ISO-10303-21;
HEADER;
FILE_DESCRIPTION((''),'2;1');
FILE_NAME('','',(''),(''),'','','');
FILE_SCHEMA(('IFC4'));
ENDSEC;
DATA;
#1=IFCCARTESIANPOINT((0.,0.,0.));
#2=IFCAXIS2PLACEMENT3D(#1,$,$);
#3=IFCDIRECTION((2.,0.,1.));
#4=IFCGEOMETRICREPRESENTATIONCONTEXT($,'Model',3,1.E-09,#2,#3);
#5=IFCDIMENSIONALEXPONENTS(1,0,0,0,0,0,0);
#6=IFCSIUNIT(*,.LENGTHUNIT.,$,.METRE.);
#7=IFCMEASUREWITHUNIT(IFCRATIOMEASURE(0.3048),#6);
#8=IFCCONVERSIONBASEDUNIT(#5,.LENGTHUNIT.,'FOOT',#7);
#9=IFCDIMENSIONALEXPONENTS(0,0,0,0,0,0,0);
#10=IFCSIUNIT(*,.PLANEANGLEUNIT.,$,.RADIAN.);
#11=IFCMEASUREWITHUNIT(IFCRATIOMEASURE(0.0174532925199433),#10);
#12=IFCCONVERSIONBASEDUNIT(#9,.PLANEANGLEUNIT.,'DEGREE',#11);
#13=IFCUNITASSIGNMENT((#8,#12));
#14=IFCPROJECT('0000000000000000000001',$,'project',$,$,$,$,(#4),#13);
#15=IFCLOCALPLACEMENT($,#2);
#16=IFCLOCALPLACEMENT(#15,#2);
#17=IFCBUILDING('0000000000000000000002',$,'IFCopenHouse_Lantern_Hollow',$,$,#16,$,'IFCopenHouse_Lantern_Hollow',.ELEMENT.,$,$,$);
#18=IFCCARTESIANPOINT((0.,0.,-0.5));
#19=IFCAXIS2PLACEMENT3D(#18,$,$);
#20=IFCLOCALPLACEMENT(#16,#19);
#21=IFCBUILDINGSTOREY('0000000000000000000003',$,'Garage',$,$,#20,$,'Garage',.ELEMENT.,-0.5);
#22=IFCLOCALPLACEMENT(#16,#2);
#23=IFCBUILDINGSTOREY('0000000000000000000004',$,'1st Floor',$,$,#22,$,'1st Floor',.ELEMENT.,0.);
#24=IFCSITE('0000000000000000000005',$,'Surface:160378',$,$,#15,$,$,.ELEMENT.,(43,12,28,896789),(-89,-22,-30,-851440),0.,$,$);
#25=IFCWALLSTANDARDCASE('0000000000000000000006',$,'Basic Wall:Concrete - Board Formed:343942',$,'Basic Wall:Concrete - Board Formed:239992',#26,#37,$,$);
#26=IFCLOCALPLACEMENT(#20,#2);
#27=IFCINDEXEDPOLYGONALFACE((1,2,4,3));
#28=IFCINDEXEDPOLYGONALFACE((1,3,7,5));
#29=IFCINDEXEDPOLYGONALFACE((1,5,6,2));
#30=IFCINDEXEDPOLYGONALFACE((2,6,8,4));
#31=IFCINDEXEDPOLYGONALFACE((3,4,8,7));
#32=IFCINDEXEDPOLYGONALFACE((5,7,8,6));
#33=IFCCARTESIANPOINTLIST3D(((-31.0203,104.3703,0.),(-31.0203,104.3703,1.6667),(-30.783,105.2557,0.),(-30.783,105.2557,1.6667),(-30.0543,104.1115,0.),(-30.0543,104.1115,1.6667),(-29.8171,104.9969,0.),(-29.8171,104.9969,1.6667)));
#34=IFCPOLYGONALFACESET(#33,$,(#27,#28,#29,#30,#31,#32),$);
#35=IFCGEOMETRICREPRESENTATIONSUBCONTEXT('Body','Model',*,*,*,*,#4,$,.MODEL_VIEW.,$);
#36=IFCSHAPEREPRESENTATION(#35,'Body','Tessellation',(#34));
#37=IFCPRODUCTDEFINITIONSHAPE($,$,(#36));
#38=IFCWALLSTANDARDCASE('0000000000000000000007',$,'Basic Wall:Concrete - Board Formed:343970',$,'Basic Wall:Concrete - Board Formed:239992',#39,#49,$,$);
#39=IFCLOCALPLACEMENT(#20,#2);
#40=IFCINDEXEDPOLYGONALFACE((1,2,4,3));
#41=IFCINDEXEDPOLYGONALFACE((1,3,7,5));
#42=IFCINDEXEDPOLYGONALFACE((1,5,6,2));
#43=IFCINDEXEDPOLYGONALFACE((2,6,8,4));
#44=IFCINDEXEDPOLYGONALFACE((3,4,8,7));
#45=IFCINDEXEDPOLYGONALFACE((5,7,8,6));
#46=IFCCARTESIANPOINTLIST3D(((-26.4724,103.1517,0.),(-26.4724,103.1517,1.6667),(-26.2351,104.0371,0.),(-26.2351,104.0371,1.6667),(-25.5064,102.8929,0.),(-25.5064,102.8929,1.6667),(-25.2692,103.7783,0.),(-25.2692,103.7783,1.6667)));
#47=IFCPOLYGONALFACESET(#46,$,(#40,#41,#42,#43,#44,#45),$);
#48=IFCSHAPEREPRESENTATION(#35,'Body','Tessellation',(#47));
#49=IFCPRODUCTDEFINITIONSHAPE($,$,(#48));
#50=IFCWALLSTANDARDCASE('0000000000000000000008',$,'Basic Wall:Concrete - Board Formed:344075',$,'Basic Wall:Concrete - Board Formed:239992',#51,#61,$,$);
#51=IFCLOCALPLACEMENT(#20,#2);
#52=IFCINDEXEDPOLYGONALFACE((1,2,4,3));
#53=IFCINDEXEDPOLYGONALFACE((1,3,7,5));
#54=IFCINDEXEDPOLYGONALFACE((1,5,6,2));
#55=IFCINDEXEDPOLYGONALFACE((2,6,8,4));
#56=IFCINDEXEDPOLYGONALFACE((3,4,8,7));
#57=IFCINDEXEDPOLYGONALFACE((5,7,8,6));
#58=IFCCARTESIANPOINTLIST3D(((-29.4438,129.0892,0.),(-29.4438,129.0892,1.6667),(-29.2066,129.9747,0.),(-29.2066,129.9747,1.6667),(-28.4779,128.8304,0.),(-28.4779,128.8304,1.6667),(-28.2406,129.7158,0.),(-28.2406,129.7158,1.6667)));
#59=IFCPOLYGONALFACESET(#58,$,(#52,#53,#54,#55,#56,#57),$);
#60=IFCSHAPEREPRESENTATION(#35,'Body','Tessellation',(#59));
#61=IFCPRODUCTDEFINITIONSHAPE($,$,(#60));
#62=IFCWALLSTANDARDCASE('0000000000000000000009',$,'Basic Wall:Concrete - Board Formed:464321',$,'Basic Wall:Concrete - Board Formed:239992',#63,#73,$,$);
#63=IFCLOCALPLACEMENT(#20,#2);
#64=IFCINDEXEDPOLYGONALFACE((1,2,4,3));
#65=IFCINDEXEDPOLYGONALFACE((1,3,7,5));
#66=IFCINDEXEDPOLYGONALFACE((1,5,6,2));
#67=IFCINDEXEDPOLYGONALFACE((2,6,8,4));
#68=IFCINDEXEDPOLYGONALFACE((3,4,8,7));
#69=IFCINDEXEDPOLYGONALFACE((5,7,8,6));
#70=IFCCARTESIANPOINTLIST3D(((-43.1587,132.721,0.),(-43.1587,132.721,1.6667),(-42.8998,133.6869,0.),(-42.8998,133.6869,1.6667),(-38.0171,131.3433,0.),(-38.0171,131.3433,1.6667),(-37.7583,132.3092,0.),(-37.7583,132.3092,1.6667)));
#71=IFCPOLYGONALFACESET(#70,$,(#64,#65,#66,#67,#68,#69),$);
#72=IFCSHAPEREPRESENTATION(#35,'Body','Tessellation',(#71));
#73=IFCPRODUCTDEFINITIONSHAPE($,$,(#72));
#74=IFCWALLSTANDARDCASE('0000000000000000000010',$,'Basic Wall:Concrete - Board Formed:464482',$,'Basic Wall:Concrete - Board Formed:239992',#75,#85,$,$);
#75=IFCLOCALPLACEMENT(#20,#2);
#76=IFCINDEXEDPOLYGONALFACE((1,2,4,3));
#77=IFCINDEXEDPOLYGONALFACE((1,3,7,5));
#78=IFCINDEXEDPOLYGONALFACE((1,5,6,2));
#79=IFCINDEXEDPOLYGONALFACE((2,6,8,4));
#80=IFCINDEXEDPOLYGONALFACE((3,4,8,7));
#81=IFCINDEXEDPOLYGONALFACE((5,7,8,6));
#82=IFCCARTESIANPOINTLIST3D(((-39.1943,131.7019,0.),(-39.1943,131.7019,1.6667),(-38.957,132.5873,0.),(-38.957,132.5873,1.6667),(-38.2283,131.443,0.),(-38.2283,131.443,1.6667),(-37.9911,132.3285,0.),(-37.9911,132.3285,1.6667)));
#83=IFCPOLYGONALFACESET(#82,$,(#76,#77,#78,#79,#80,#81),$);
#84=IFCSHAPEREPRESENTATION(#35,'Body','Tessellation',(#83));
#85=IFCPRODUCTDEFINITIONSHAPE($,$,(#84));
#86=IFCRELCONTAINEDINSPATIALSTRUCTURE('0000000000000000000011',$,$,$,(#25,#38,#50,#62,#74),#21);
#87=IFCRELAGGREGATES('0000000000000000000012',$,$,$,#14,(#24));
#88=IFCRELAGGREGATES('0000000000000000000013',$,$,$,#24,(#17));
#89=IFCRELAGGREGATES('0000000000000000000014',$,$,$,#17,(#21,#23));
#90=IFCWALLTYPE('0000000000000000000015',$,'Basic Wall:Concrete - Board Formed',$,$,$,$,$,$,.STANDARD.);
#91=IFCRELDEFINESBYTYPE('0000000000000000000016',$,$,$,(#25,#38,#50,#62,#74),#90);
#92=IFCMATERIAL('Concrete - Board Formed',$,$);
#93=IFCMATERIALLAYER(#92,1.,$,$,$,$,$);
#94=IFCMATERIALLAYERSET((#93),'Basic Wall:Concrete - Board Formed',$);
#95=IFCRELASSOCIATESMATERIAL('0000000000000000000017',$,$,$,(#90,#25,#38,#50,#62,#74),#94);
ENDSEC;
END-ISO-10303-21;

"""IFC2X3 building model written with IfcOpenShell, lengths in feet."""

from ifc_helpers import new_model, entity, si_unit, converted_unit, direction, frame, frame_2d, origin, place, context, subcontext, project, spatial, rectangle, extrude, material, layer, layer_set, layer_usage, type_object, element, save


model = new_model("IFC2X3")

# Units and contexts
model_context = context("Model", 3, precision=1e-09, world=origin(), true_north=direction((2.0, 0.0, 1.0)))
body_context = subcontext(model_context, "Body", "Model", "MODEL_VIEW")
ifc_project = project(units=[converted_unit("LENGTHUNIT", "FOOT", entity("IfcRatioMeasure", 0.3048), si_unit("LENGTHUNIT", "METRE"), dimensions=[1, 0, 0, 0, 0, 0, 0]), converted_unit("PLANEANGLEUNIT", "DEGREE", entity("IfcRatioMeasure", 0.0174532925199433), si_unit("PLANEANGLEUNIT", "RADIAN"), dimensions=[0, 0, 0, 0, 0, 0, 0])], contexts=[model_context])

# Site, building, storey
site_placement = place(None, origin())
site = spatial("IfcSite", under=ifc_project, at=site_placement, Name="Surface:160378", CompositionType="ELEMENT", RefLatitude=(43, 12, 28, 896789), RefLongitude=(-89, -22, -30, -851440), RefElevation=0.0)
building_placement = place(site_placement, origin())
building = spatial("IfcBuilding", under=site, at=building_placement, Name="IFCopenHouse_Lantern_Hollow", LongName="IFCopenHouse_Lantern_Hollow", CompositionType="ELEMENT")
storey_1_placement = place(building_placement, frame((0.0, 0.0, -0.5)))
storey_1 = spatial("IfcBuildingStorey", under=building, at=storey_1_placement, Name="Garage", LongName="Garage", CompositionType="ELEMENT", Elevation=-0.5)

# Shared definitions
storey_2_placement = place(building_placement, origin())
storey_2 = spatial("IfcBuildingStorey", under=building, at=storey_2_placement, Name="1st Floor", LongName="1st Floor", CompositionType="ELEMENT", Elevation=0.0)

# Walls
ifc_material_1 = material(Name="Concrete - Board Formed")
ifc_layer_1 = layer(ifc_material_1, 1.0)
ifc_layer_set_1 = layer_set([ifc_layer_1], Name="Basic Wall:Concrete - Board Formed")
wall_type_1 = type_object("IfcWallType", Name="Basic Wall:Concrete - Board Formed", PredefinedType="STANDARD", material=ifc_layer_set_1)
ifc_layer_usage_1 = layer_usage(ifc_layer_set_1, "AXIS2", "NEGATIVE", 0.5)
wall_1_placement = place(storey_1_placement, frame((-30.3, 105.1263, 0.0), z_axis=(0.0, 0.0, 1.0), x_axis=(-0.258819, -0.965926, 0.0)))
element("IfcWallStandardCase", 1, at=wall_1_placement, inside=storey_1, type_object=wall_type_1, material=ifc_layer_usage_1, Name="Basic Wall:Concrete - Board Formed:343942", ObjectType="Basic Wall:Concrete - Board Formed:239992", context=body_context, shape_type="SweptSolid", body=[
    extrude(rectangle(XDim=0.9167, YDim=1.0, at=frame_2d((0.4583, 0.0), x_axis=(-1.0, 0.0))), origin(), (0.0, 0.0, 1.0), 1.6667),
])
ifc_layer_usage_2 = layer_usage(ifc_layer_set_1, "AXIS2", "NEGATIVE", 0.5)
wall_2_placement = place(storey_1_placement, frame((-25.7521, 103.9077, 0.0), z_axis=(0.0, 0.0, 1.0), x_axis=(-0.258819, -0.965926, 0.0)))
element("IfcWallStandardCase", 2, at=wall_2_placement, inside=storey_1, type_object=wall_type_1, material=ifc_layer_usage_2, Name="Basic Wall:Concrete - Board Formed:343970", ObjectType="Basic Wall:Concrete - Board Formed:239992", context=body_context, shape_type="SweptSolid", body=[
    extrude(rectangle(XDim=0.9167, YDim=1.0, at=frame_2d((0.4583, 0.0), x_axis=(-1.0, 0.0))), origin(), (0.0, 0.0, 1.0), 1.6667),
])
ifc_layer_usage_3 = layer_usage(ifc_layer_set_1, "AXIS2", "NEGATIVE", 0.5)
wall_3_placement = place(storey_1_placement, frame((-28.7236, 129.8453, 0.0), z_axis=(0.0, 0.0, 1.0), x_axis=(-0.258819, -0.965926, 0.0)))
element("IfcWallStandardCase", 3, at=wall_3_placement, inside=storey_1, type_object=wall_type_1, material=ifc_layer_usage_3, Name="Basic Wall:Concrete - Board Formed:344075", ObjectType="Basic Wall:Concrete - Board Formed:239992", context=body_context, shape_type="SweptSolid", body=[
    extrude(rectangle(XDim=0.9167, YDim=1.0, at=frame_2d((0.4583, 0.0), x_axis=(-1.0, 0.0))), origin(), (0.0, 0.0, 1.0), 1.6667),
])
ifc_layer_usage_4 = layer_usage(ifc_layer_set_1, "AXIS2", "NEGATIVE", 0.5)
wall_4_placement = place(storey_1_placement, frame((-43.0293, 133.2039, 0.0), z_axis=(0.0, 0.0, 1.0), x_axis=(0.965926, -0.258819, 0.0)))
element("IfcWallStandardCase", 4, at=wall_4_placement, inside=storey_1, type_object=wall_type_1, material=ifc_layer_usage_4, Name="Basic Wall:Concrete - Board Formed:464321", ObjectType="Basic Wall:Concrete - Board Formed:239992", context=body_context, shape_type="SweptSolid", body=[
    extrude(rectangle(XDim=5.3229, YDim=1.0, at=frame_2d((2.6615, 0.0), x_axis=(-1.0, 0.0))), origin(), (0.0, 0.0, 1.0), 1.6667),
])
ifc_layer_usage_5 = layer_usage(ifc_layer_set_1, "AXIS2", "NEGATIVE", 0.5)
wall_5_placement = place(storey_1_placement, frame((-38.4741, 132.4579, 0.0), z_axis=(0.0, 0.0, 1.0), x_axis=(-0.258819, -0.965926, 0.0)))
element("IfcWallStandardCase", 5, at=wall_5_placement, inside=storey_1, type_object=wall_type_1, material=ifc_layer_usage_5, Name="Basic Wall:Concrete - Board Formed:464482", ObjectType="Basic Wall:Concrete - Board Formed:239992", context=body_context, shape_type="SweptSolid", body=[
    extrude(rectangle(XDim=0.9167, YDim=1.0, at=frame_2d((0.4583, 0.0), x_axis=(-1.0, 0.0))), origin(), (0.0, 0.0, 1.0), 1.6667),
])

save(model, "model.ifc")
